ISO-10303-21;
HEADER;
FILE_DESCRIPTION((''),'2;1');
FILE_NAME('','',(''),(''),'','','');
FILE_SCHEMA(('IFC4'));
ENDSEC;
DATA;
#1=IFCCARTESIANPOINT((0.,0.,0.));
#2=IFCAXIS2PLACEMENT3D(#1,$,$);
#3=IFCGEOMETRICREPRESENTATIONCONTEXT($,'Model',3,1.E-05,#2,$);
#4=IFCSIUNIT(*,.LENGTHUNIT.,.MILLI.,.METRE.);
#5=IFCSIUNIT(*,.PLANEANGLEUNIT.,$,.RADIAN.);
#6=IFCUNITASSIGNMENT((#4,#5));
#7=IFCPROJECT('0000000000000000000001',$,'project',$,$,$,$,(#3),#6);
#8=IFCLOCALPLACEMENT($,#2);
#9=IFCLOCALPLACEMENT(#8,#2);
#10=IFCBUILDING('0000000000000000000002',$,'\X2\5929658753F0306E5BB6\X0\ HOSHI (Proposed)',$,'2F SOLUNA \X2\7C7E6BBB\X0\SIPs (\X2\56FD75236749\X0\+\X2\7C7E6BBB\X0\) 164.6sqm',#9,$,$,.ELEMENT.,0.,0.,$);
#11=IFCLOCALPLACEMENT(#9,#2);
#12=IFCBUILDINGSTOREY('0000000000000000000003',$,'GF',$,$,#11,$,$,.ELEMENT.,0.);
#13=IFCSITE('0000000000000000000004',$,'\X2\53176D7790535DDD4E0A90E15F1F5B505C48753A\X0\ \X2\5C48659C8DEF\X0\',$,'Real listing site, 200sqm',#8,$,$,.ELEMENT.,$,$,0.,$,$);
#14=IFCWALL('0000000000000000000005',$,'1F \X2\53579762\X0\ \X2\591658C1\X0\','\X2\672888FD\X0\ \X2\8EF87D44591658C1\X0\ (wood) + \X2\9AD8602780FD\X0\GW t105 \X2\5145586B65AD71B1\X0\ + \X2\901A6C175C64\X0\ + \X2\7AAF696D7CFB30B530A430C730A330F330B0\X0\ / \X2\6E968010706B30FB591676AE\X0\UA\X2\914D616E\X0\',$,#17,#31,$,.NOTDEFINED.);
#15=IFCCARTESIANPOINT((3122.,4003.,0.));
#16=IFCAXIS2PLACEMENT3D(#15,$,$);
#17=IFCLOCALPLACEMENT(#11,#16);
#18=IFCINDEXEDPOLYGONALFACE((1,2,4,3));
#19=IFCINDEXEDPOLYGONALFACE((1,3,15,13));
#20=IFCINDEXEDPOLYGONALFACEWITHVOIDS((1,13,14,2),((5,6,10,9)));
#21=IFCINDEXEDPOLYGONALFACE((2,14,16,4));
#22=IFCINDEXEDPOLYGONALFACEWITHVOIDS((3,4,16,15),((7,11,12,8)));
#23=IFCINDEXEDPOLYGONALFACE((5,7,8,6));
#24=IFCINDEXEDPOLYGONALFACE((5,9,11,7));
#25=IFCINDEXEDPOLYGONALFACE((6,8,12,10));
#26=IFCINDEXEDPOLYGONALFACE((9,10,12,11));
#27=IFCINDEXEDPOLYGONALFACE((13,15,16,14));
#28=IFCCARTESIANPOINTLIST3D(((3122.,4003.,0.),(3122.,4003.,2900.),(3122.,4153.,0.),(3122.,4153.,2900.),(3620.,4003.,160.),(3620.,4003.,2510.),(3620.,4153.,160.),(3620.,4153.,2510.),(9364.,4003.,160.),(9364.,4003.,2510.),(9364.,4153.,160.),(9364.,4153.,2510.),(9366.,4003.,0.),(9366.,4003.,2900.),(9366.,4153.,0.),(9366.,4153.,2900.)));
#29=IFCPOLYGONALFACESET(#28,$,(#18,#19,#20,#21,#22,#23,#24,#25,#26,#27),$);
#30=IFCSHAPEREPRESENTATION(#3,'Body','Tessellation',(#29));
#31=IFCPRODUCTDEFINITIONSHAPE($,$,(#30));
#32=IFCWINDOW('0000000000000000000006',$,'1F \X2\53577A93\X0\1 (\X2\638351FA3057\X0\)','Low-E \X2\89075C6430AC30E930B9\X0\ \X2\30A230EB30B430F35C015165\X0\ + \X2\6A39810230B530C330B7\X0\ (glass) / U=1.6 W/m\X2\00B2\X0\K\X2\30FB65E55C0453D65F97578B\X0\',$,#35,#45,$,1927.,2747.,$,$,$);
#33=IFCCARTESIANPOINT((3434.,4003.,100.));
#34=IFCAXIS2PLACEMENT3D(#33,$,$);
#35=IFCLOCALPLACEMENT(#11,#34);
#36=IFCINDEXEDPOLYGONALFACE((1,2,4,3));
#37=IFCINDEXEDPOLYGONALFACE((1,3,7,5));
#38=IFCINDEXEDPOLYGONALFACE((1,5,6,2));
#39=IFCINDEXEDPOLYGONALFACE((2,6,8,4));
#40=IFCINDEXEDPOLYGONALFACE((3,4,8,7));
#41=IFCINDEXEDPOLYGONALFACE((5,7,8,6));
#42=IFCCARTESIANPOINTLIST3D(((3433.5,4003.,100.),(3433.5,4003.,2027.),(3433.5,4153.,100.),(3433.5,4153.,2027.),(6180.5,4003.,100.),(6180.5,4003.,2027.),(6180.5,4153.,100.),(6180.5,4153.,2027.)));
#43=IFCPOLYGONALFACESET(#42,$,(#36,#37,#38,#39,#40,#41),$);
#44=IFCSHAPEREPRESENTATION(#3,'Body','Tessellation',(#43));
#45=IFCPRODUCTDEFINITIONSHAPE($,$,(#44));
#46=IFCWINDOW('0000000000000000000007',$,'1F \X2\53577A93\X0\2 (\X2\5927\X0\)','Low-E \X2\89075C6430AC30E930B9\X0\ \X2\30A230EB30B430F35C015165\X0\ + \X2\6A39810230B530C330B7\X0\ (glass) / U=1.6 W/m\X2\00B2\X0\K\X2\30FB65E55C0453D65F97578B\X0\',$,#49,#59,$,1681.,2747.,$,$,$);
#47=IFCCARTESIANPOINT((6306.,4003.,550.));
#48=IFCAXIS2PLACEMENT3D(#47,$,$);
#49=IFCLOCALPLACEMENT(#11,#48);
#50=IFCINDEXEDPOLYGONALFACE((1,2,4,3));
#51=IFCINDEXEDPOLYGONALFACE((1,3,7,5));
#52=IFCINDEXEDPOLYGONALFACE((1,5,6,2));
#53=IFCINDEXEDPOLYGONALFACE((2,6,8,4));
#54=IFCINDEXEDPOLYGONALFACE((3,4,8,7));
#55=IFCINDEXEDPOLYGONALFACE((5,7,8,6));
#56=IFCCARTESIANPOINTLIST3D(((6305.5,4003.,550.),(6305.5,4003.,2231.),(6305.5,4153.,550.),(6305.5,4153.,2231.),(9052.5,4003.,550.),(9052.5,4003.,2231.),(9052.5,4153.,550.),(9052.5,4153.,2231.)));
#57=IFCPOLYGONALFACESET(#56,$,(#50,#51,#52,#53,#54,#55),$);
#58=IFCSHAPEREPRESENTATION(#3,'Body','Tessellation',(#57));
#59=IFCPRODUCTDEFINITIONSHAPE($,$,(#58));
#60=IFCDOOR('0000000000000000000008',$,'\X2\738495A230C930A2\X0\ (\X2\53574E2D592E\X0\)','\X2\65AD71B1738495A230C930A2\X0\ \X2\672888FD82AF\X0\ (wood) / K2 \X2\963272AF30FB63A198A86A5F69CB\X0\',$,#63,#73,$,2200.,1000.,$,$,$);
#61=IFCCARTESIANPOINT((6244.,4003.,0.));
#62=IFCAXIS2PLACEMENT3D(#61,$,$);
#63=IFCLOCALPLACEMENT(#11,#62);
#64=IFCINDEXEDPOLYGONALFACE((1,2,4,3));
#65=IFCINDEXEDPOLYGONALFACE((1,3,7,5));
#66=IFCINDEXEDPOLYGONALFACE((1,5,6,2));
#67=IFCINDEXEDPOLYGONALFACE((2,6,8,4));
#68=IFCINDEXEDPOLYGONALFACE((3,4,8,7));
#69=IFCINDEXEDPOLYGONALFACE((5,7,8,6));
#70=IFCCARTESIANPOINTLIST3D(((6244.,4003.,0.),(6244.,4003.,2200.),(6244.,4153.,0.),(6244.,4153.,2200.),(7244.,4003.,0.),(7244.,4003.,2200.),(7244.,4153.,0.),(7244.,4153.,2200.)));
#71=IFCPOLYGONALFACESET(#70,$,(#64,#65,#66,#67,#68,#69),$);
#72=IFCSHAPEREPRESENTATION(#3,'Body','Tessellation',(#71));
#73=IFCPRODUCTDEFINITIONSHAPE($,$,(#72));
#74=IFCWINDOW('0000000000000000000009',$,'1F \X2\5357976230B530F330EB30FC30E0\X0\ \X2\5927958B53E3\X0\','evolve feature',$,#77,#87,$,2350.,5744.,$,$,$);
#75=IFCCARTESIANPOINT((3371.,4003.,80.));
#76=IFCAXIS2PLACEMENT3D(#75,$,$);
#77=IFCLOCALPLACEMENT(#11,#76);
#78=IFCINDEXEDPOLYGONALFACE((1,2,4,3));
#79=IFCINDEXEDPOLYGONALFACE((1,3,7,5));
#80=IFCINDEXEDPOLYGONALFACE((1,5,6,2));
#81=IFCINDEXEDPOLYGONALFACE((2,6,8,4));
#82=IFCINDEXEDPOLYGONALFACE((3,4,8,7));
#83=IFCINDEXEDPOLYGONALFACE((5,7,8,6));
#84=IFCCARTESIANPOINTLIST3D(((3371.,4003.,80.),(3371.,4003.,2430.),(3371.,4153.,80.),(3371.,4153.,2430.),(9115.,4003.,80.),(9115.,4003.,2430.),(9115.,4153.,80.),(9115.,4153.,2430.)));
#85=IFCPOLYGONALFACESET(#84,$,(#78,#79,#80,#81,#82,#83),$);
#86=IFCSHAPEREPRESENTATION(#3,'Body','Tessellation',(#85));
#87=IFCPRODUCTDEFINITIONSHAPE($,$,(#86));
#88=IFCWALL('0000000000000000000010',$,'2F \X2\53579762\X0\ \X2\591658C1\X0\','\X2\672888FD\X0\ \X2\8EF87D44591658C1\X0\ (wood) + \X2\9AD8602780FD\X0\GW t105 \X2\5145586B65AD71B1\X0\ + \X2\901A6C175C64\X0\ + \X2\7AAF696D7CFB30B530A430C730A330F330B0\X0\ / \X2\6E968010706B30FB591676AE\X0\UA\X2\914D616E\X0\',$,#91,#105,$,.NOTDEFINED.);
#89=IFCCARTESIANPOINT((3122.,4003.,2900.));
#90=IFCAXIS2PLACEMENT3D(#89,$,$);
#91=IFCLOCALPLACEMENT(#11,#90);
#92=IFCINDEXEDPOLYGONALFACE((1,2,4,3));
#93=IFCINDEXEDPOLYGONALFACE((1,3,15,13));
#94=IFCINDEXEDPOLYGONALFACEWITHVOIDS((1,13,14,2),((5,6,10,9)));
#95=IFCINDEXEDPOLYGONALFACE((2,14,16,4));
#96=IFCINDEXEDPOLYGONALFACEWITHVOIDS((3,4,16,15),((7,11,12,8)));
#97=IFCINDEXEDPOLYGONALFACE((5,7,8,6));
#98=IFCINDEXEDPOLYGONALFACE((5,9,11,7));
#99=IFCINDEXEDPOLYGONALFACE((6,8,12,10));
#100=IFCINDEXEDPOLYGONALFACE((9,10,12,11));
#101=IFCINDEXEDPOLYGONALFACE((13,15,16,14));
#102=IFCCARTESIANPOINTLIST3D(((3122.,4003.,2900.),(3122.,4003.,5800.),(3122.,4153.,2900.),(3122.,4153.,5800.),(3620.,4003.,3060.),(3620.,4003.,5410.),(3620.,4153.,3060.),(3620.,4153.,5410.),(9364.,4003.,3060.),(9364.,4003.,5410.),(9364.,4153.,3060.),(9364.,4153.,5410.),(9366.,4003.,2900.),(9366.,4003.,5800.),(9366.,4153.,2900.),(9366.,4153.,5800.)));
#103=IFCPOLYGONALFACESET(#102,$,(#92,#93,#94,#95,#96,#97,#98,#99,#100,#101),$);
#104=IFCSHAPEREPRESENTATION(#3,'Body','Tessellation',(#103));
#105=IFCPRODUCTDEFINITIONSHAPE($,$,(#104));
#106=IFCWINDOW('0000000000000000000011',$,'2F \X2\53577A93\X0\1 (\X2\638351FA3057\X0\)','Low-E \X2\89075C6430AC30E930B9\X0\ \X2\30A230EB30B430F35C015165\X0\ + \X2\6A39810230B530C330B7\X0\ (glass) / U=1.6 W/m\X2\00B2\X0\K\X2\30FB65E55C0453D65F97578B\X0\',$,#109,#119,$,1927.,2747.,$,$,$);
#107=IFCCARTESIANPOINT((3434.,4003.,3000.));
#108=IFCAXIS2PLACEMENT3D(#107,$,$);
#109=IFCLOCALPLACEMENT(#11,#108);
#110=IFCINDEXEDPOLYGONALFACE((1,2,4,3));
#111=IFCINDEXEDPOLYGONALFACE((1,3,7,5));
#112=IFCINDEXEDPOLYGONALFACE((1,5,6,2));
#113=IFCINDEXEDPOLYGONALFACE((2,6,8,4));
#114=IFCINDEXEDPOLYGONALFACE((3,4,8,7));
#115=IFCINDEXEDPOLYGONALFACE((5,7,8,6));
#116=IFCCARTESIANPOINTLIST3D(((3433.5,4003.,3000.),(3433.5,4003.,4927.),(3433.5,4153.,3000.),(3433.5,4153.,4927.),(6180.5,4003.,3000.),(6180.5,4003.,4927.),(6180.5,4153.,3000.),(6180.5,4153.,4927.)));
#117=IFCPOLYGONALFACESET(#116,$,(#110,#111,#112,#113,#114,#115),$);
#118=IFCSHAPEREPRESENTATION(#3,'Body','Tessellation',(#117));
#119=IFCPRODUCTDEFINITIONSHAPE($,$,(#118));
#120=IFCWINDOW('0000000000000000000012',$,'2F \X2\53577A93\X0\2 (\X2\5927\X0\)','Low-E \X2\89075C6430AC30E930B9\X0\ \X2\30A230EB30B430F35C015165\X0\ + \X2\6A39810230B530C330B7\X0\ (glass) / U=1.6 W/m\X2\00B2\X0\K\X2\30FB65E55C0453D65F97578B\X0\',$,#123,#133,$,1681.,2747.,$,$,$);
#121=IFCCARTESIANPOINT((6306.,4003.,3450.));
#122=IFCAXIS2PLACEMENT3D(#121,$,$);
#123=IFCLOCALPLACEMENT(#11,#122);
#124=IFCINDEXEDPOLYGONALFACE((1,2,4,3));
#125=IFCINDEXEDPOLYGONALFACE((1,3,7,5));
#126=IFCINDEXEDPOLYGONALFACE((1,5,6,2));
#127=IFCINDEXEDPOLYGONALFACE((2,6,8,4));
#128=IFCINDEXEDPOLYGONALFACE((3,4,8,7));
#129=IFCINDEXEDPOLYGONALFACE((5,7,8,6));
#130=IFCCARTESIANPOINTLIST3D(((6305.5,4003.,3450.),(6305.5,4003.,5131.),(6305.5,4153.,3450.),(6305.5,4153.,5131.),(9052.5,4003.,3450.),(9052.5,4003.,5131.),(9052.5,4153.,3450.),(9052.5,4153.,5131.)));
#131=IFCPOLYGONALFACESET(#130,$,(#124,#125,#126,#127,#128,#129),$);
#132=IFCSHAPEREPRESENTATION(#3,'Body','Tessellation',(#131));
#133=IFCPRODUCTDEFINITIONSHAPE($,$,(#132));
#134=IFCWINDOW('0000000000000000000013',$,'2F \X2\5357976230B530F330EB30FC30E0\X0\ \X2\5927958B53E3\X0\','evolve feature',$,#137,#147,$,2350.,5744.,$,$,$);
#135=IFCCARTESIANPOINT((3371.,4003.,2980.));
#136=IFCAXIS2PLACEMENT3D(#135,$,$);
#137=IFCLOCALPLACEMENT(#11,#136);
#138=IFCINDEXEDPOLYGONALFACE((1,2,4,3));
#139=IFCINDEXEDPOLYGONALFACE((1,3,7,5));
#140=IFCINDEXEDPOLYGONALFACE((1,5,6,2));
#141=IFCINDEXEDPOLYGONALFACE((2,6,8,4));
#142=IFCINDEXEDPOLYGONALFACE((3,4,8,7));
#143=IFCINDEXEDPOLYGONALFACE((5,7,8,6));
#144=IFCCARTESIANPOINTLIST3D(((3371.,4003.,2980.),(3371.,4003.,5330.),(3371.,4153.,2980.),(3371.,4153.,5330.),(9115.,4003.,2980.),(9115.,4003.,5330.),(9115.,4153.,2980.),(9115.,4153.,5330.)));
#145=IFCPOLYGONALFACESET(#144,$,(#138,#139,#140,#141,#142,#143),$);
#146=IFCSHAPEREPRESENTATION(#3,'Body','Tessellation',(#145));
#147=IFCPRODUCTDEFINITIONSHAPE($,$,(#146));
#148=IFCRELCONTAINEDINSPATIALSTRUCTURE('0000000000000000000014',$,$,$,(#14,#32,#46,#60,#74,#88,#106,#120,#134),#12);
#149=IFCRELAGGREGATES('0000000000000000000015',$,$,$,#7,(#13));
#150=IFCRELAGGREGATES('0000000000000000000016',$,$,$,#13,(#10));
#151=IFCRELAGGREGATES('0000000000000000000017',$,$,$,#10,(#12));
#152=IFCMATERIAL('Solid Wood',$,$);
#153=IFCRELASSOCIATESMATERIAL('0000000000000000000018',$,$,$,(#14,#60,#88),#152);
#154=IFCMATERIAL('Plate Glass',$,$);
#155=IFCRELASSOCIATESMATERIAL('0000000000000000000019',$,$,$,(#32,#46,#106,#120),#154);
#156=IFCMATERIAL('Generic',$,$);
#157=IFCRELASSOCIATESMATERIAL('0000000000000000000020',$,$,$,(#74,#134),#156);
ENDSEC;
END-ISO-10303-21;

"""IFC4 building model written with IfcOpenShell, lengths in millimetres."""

from ifc_helpers import new_model, si_unit, frame, frame_2d, origin, place, context, project, spatial, rectangle, extrude, material, element, fill, save


model = new_model("IFC4")

# Units and contexts
model_context = context("Model", 3, precision=1e-05, world=origin())
ifc_project = project(units=[si_unit("LENGTHUNIT", "METRE", prefix="MILLI"), si_unit("PLANEANGLEUNIT", "RADIAN")], contexts=[model_context])

# Site, building, storey
site_placement = place(None, origin())
site = spatial("IfcSite", under=ifc_project, at=site_placement, Name="北海道川上郡弟子屈町 屈斜路", ObjectType="Real listing site, 200sqm", CompositionType="ELEMENT", RefElevation=0.0)
building_placement = place(site_placement, origin())
building = spatial("IfcBuilding", under=site, at=building_placement, Name="天文台の家 HOSHI (Proposed)", ObjectType="2F SOLUNA 籾殻SIPs (国産杉+籾殻) 164.6sqm", CompositionType="ELEMENT", ElevationOfRefHeight=0.0, ElevationOfTerrain=0.0)
storey_placement = place(building_placement, origin())
storey = spatial("IfcBuildingStorey", under=building, at=storey_placement, Name="GF", CompositionType="ELEMENT", Elevation=0.0)

# Shared definitions
ifc_material_1 = material(Name="Solid Wood")
ifc_material_2 = material(Name="Generic")

# Wall, openings, windows, door
wall_1_placement = place(storey_placement, frame((3122.0, 4003.0, 0.0)))
wall_1 = element("IfcWall", 1, at=wall_1_placement, inside=storey, material=ifc_material_1, Name="1F 南面 外壁", Description="木製 軸組外壁 (wood) + 高性能GW t105 充填断熱 + 通気層 + 窯業系サイディング / 準耐火・外皮UA配慮", PredefinedType="NOTDEFINED", context=model_context, shape_type="SweptSolid", body=[
    extrude(rectangle(XDim=6244.0, YDim=150.0, at=frame_2d((3122.0, 75.0))), frame((3122.0, 4003.0, 0.0)), (0.0, 0.0, 1.0), 2900.0),
])
opening_1_placement = place(storey_placement, frame((3434.0, 4003.0, 100.0)))
opening_1 = element("IfcOpeningElement", 2, at=opening_1_placement, cuts=wall_1, PredefinedType="NOTDEFINED", context=model_context, shape_type="SweptSolid", body=[
    extrude(rectangle(XDim=2747.0, YDim=150.0, at=frame_2d((1373.0, 75.0))), frame((3434.0, 4003.0, 100.0)), (0.0, 0.0, 1.0), 1927.0),
])
opening_2_placement = place(storey_placement, frame((6306.0, 4003.0, 550.0)))
opening_2 = element("IfcOpeningElement", 3, at=opening_2_placement, cuts=wall_1, PredefinedType="NOTDEFINED", context=model_context, shape_type="SweptSolid", body=[
    extrude(rectangle(XDim=2747.0, YDim=150.0, at=frame_2d((1373.0, 75.0))), frame((6306.0, 4003.0, 550.0)), (0.0, 0.0, 1.0), 1681.0),
])
opening_3_placement = place(storey_placement, frame((6244.0, 4003.0, 0.0)))
opening_3 = element("IfcOpeningElement", 4, at=opening_3_placement, cuts=wall_1, PredefinedType="NOTDEFINED", context=model_context, shape_type="SweptSolid", body=[
    extrude(rectangle(XDim=1000.0, YDim=150.0, at=frame_2d((500.0, 75.0))), frame((6244.0, 4003.0, 0.0)), (0.0, 0.0, 1.0), 2200.0),
])
opening_4_placement = place(storey_placement, frame((3371.0, 4003.0, 80.0)))
opening_4 = element("IfcOpeningElement", 5, at=opening_4_placement, cuts=wall_1, PredefinedType="NOTDEFINED", context=model_context, shape_type="SweptSolid", body=[
    extrude(rectangle(XDim=5744.0, YDim=150.0, at=frame_2d((2872.0, 75.0))), frame((3371.0, 4003.0, 80.0)), (0.0, 0.0, 1.0), 2350.0),
])
ifc_material_3 = material(Name="Plate Glass")
window_1_placement = place(storey_placement, frame((3434.0, 4003.0, 100.0)))
window_1 = element("IfcWindow", 6, at=window_1_placement, inside=storey, material=ifc_material_3, Name="1F 南窓1 (掃出し)", Description="Low-E 複層ガラス アルゴン封入 + 樹脂サッシ (glass) / U=1.6 W/m²K・日射取得型", OverallHeight=1927.0, OverallWidth=2747.0, context=model_context, shape_type="SweptSolid", body=[
    extrude(rectangle(XDim=2747.0, YDim=150.0, at=frame_2d((1373.0, 75.0))), frame((3434.0, 4003.0, 100.0)), (0.0, 0.0, 1.0), 1927.0),
])
fill(opening_1, window_1)
window_2_placement = place(storey_placement, frame((6306.0, 4003.0, 550.0)))
window_2 = element("IfcWindow", 7, at=window_2_placement, inside=storey, material=ifc_material_3, Name="1F 南窓2 (大)", Description="Low-E 複層ガラス アルゴン封入 + 樹脂サッシ (glass) / U=1.6 W/m²K・日射取得型", OverallHeight=1681.0, OverallWidth=2747.0, context=model_context, shape_type="SweptSolid", body=[
    extrude(rectangle(XDim=2747.0, YDim=150.0, at=frame_2d((1373.0, 75.0))), frame((6306.0, 4003.0, 550.0)), (0.0, 0.0, 1.0), 1681.0),
])
fill(opening_2, window_2)
door_placement = place(storey_placement, frame((6244.0, 4003.0, 0.0)))
door = element("IfcDoor", 8, at=door_placement, inside=storey, material=ifc_material_1, Name="玄関ドア (南中央)", Description="断熱玄関ドア 木製芯 (wood) / K2 防犯・採風機構", OverallHeight=2200.0, OverallWidth=1000.0, context=model_context, shape_type="SweptSolid", body=[
    extrude(rectangle(XDim=1000.0, YDim=150.0, at=frame_2d((500.0, 75.0))), frame((6244.0, 4003.0, 0.0)), (0.0, 0.0, 1.0), 2200.0),
])
fill(opening_3, door)
window_3_placement = place(storey_placement, frame((3371.0, 4003.0, 80.0)))
window_3 = element("IfcWindow", 9, at=window_3_placement, inside=storey, material=ifc_material_2, Name="1F 南面サンルーム 大開口", Description="evolve feature", OverallHeight=2350.0, OverallWidth=5744.0, context=model_context, shape_type="SweptSolid", body=[
    extrude(rectangle(XDim=5744.0, YDim=150.0, at=frame_2d((2872.0, 75.0))), frame((3371.0, 4003.0, 80.0)), (0.0, 0.0, 1.0), 2350.0),
])
fill(opening_4, window_3)

# Wall, openings, windows
wall_2_placement = place(storey_placement, frame((3122.0, 4003.0, 2900.0)))
wall_2 = element("IfcWall", 10, at=wall_2_placement, inside=storey, material=ifc_material_1, Name="2F 南面 外壁", Description="木製 軸組外壁 (wood) + 高性能GW t105 充填断熱 + 通気層 + 窯業系サイディング / 準耐火・外皮UA配慮", PredefinedType="NOTDEFINED", context=model_context, shape_type="SweptSolid", body=[
    extrude(rectangle(XDim=6244.0, YDim=150.0, at=frame_2d((3122.0, 75.0))), frame((3122.0, 4003.0, 2900.0)), (0.0, 0.0, 1.0), 2900.0),
])
opening_5_placement = place(storey_placement, frame((3434.0, 4003.0, 3000.0)))
opening_5 = element("IfcOpeningElement", 11, at=opening_5_placement, cuts=wall_2, PredefinedType="NOTDEFINED", context=model_context, shape_type="SweptSolid", body=[
    extrude(rectangle(XDim=2747.0, YDim=150.0, at=frame_2d((1373.0, 75.0))), frame((3434.0, 4003.0, 3000.0)), (0.0, 0.0, 1.0), 1927.0),
])
opening_6_placement = place(storey_placement, frame((6306.0, 4003.0, 3450.0)))
opening_6 = element("IfcOpeningElement", 12, at=opening_6_placement, cuts=wall_2, PredefinedType="NOTDEFINED", context=model_context, shape_type="SweptSolid", body=[
    extrude(rectangle(XDim=2747.0, YDim=150.0, at=frame_2d((1373.0, 75.0))), frame((6306.0, 4003.0, 3450.0)), (0.0, 0.0, 1.0), 1681.0),
])
opening_7_placement = place(storey_placement, frame((3371.0, 4003.0, 2980.0)))
opening_7 = element("IfcOpeningElement", 13, at=opening_7_placement, cuts=wall_2, PredefinedType="NOTDEFINED", context=model_context, shape_type="SweptSolid", body=[
    extrude(rectangle(XDim=5744.0, YDim=150.0, at=frame_2d((2872.0, 75.0))), frame((3371.0, 4003.0, 2980.0)), (0.0, 0.0, 1.0), 2350.0),
])
window_4_placement = place(storey_placement, frame((3434.0, 4003.0, 3000.0)))
window_4 = element("IfcWindow", 14, at=window_4_placement, inside=storey, material=ifc_material_3, Name="2F 南窓1 (掃出し)", Description="Low-E 複層ガラス アルゴン封入 + 樹脂サッシ (glass) / U=1.6 W/m²K・日射取得型", OverallHeight=1927.0, OverallWidth=2747.0, context=model_context, shape_type="SweptSolid", body=[
    extrude(rectangle(XDim=2747.0, YDim=150.0, at=frame_2d((1373.0, 75.0))), frame((3434.0, 4003.0, 3000.0)), (0.0, 0.0, 1.0), 1927.0),
])
fill(opening_5, window_4)
window_5_placement = place(storey_placement, frame((6306.0, 4003.0, 3450.0)))
window_5 = element("IfcWindow", 15, at=window_5_placement, inside=storey, material=ifc_material_3, Name="2F 南窓2 (大)", Description="Low-E 複層ガラス アルゴン封入 + 樹脂サッシ (glass) / U=1.6 W/m²K・日射取得型", OverallHeight=1681.0, OverallWidth=2747.0, context=model_context, shape_type="SweptSolid", body=[
    extrude(rectangle(XDim=2747.0, YDim=150.0, at=frame_2d((1373.0, 75.0))), frame((6306.0, 4003.0, 3450.0)), (0.0, 0.0, 1.0), 1681.0),
])
fill(opening_6, window_5)
window_6_placement = place(storey_placement, frame((3371.0, 4003.0, 2980.0)))
window_6 = element("IfcWindow", 16, at=window_6_placement, inside=storey, material=ifc_material_2, Name="2F 南面サンルーム 大開口", Description="evolve feature", OverallHeight=2350.0, OverallWidth=5744.0, context=model_context, shape_type="SweptSolid", body=[
    extrude(rectangle(XDim=5744.0, YDim=150.0, at=frame_2d((2872.0, 75.0))), frame((3371.0, 4003.0, 2980.0)), (0.0, 0.0, 1.0), 2350.0),
])
fill(opening_7, window_6)

save(model, "model.ifc")
